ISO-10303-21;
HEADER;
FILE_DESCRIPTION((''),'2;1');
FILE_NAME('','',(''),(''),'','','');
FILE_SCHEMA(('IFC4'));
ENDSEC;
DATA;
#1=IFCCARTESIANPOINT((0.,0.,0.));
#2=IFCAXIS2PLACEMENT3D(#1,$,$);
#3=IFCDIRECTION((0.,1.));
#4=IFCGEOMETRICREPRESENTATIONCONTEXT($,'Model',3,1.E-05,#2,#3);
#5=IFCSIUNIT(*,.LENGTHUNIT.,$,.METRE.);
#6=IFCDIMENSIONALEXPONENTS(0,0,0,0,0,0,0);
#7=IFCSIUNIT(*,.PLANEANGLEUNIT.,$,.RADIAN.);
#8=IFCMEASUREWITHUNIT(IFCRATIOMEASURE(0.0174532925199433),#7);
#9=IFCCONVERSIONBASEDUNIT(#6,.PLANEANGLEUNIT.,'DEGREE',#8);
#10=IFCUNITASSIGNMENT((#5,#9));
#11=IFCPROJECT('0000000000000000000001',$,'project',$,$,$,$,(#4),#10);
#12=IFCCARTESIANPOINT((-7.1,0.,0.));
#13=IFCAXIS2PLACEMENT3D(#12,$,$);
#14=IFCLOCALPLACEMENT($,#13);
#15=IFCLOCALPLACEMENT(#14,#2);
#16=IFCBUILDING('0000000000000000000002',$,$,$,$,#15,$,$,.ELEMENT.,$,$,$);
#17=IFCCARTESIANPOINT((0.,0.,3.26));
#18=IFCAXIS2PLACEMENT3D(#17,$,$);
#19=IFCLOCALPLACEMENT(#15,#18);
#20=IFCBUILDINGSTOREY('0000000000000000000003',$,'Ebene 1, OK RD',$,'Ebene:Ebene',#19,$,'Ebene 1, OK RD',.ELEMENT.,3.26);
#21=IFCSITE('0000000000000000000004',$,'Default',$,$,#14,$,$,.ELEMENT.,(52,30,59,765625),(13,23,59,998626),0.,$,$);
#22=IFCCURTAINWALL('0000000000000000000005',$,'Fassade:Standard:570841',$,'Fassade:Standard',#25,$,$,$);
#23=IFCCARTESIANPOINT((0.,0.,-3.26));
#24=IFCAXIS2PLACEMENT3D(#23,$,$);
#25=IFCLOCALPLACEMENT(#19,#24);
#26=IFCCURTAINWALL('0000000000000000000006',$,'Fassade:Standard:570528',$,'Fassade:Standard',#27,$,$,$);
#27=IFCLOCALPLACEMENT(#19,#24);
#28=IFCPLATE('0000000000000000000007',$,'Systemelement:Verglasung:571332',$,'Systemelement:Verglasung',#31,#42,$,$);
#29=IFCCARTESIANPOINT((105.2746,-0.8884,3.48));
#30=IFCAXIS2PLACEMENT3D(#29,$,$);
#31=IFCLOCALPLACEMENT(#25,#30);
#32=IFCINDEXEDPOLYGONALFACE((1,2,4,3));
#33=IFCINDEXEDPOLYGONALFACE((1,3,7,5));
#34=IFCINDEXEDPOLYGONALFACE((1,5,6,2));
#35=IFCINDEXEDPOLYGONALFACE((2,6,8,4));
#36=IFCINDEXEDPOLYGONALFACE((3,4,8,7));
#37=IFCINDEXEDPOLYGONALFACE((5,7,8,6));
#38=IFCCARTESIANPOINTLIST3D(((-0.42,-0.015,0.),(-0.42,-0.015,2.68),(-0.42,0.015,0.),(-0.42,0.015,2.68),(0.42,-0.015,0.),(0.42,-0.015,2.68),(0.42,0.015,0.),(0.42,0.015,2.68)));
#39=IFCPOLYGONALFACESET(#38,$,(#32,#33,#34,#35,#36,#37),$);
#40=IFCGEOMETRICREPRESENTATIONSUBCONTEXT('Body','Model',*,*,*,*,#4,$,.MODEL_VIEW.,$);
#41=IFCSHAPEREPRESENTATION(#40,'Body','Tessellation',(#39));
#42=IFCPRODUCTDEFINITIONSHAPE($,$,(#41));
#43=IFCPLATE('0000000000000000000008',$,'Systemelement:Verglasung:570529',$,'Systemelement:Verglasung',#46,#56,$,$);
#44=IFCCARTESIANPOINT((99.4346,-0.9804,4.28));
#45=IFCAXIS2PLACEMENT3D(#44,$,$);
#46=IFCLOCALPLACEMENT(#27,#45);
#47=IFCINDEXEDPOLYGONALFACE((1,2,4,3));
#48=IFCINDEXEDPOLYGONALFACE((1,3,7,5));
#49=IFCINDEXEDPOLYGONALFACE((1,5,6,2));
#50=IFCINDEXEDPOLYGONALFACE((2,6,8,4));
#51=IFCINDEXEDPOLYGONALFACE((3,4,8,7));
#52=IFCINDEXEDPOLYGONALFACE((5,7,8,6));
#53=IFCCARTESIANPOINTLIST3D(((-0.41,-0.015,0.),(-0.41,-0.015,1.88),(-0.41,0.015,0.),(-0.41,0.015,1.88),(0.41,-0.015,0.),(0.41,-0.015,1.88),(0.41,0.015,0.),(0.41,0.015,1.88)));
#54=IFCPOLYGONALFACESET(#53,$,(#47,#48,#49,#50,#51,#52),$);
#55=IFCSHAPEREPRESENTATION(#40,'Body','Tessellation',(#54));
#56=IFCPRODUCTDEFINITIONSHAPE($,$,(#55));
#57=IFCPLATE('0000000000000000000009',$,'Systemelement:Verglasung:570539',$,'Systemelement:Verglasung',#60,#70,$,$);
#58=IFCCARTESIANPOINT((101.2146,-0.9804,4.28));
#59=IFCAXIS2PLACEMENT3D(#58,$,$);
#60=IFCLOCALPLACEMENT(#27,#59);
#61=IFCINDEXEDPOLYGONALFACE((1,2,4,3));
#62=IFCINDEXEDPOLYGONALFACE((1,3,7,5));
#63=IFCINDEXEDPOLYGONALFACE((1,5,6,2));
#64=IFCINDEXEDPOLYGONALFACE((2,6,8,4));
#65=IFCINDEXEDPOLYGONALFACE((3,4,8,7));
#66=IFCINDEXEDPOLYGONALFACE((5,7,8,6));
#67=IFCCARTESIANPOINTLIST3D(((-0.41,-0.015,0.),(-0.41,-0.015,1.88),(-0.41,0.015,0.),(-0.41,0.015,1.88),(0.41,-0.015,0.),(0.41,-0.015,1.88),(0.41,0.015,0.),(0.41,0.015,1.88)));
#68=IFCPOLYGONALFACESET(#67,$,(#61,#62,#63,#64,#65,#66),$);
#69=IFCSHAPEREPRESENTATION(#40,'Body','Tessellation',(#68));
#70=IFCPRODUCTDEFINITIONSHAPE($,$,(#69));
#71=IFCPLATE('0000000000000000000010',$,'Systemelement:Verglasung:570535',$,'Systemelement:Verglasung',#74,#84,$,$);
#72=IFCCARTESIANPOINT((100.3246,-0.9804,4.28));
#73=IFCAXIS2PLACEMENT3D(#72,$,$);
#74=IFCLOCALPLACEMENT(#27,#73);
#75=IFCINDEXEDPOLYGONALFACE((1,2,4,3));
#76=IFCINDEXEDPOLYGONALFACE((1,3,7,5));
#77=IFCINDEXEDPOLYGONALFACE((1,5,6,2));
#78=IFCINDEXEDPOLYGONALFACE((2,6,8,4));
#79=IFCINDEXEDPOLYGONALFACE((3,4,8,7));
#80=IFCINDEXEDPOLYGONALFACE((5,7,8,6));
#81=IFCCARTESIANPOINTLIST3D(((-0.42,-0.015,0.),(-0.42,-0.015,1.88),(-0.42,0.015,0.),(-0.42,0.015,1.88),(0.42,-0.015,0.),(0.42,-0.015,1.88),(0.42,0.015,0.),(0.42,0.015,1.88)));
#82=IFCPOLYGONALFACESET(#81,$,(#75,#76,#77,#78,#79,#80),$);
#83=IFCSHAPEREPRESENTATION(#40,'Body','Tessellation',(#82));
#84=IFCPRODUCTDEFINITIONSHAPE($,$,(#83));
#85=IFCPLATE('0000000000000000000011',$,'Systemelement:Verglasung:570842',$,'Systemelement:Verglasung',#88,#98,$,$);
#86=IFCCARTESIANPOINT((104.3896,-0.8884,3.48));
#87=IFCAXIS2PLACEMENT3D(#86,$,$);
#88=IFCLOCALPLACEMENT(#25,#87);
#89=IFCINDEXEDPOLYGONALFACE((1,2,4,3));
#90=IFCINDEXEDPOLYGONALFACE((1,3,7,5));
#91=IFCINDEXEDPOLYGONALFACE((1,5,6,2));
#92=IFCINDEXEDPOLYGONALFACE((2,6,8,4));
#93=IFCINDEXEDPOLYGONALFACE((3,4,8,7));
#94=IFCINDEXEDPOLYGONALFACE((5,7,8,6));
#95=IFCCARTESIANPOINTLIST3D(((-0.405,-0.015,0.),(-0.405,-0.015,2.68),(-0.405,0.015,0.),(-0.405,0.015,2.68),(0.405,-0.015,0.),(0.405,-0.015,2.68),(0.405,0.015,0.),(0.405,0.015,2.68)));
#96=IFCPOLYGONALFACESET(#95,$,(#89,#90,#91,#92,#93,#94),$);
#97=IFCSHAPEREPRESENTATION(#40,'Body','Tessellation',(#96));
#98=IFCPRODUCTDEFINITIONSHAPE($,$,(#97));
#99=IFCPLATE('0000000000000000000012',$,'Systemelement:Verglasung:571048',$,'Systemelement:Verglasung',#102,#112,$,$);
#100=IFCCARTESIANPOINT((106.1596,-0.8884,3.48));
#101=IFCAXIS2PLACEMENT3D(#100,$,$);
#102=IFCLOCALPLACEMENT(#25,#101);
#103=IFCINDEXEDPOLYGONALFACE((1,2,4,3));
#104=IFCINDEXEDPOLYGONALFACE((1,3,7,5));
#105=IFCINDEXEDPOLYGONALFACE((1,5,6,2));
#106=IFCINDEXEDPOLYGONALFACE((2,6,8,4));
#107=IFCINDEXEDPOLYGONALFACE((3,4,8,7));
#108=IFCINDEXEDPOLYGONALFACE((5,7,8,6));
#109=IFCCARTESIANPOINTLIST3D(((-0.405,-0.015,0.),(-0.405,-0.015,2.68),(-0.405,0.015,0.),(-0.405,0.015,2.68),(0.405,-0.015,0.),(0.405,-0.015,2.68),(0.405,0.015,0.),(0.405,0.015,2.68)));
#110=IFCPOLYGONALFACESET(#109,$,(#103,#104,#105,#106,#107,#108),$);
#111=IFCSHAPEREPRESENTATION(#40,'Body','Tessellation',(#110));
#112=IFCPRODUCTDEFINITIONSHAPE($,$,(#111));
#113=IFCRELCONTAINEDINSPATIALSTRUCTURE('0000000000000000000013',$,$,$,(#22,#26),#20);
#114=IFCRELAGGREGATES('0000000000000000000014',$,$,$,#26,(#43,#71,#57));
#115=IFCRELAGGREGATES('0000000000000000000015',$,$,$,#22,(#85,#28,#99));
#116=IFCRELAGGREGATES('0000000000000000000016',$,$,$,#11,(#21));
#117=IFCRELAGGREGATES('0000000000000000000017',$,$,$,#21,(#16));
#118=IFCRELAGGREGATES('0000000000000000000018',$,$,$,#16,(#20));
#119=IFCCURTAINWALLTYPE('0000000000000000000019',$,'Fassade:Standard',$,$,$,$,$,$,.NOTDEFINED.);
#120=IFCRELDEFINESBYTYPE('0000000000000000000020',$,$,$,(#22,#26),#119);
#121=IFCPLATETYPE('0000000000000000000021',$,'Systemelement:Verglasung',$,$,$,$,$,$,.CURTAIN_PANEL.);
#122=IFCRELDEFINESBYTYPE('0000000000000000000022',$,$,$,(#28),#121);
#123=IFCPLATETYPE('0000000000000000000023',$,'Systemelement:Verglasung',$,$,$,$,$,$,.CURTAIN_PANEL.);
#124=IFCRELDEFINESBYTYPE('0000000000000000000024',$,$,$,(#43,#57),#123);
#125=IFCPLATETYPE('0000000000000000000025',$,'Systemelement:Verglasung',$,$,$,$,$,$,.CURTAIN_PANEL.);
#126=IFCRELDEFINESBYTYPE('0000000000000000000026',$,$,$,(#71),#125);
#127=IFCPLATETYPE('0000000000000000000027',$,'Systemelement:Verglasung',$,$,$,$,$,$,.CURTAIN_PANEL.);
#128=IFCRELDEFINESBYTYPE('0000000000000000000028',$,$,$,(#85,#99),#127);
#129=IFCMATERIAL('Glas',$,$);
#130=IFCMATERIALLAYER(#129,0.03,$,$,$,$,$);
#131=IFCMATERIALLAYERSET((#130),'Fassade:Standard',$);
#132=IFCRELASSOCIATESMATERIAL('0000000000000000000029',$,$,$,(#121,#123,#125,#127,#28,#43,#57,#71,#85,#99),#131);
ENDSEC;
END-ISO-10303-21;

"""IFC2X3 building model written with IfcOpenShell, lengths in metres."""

from ifc_helpers import new_model, entity, si_unit, converted_unit, direction, frame, origin, origin_2d_with_axis, place, context, subcontext, project, spatial, rectangle, extrude, source, transform, mapped, material, layer, layer_set, layer_usage, type_object, type_shapes, element, aggregate, save


model = new_model("IFC2X3")

# Units and contexts
model_context = context("Model", 3, precision=1e-05, world=origin(), true_north=direction((0.0, 1.0)))
body_context = subcontext(model_context, "Body", "Model", "MODEL_VIEW")
ifc_project = project(units=[si_unit("LENGTHUNIT", "METRE"), converted_unit("PLANEANGLEUNIT", "DEGREE", entity("IfcRatioMeasure", 0.0174532925199433), si_unit("PLANEANGLEUNIT", "RADIAN"), dimensions=[0, 0, 0, 0, 0, 0, 0])], contexts=[model_context])

# Site, building, storey
site_placement = place(None, frame((-7.1, 0.0, 0.0)))
site = spatial("IfcSite", under=ifc_project, at=site_placement, Name="Default", CompositionType="ELEMENT", RefLatitude=(52, 30, 59, 765625), RefLongitude=(13, 23, 59, 998626), RefElevation=0.0)
building_placement = place(site_placement, origin())
building = spatial("IfcBuilding", under=site, at=building_placement, CompositionType="ELEMENT")
storey_placement = place(building_placement, frame((0.0, 0.0, 3.26)))
storey = spatial("IfcBuildingStorey", under=building, at=storey_placement, Name="Ebene 1, OK RD", ObjectType="Ebene:Ebene", LongName="Ebene 1, OK RD", CompositionType="ELEMENT", Elevation=3.26)

# Curtain wall
curtain_wall_type = type_object("IfcCurtainWallType", Name="Fassade:Standard", PredefinedType="NOTDEFINED")
curtain_wall_1_placement = place(storey_placement, frame((0.0, 0.0, -3.26)))
curtain_wall_1 = element("IfcCurtainWall", 1, at=curtain_wall_1_placement, inside=storey, type_object=curtain_wall_type, Name="Fassade:Standard:570841", ObjectType="Fassade:Standard")

# Curtain wall
curtain_wall_2_placement = place(storey_placement, frame((0.0, 0.0, -3.26)))
curtain_wall_2 = element("IfcCurtainWall", 2, at=curtain_wall_2_placement, inside=storey, type_object=curtain_wall_type, Name="Fassade:Standard:570528", ObjectType="Fassade:Standard")

# Plates
ifc_material_1 = material(Name="Glas")
ifc_layer_1 = layer(ifc_material_1, 0.03)
ifc_layer_set_1 = layer_set([ifc_layer_1], Name="Fassade:Standard")
ifc_layer_usage_1 = layer_usage(ifc_layer_set_1, "AXIS3", "POSITIVE", 0.0)
plate_type_1 = type_object("IfcPlateType", Name="Systemelement:Verglasung", PredefinedType="CURTAIN_PANEL", material=ifc_layer_set_1)
shared_shape_1 = source(origin(), body_context, "Body", "SweptSolid", [
    extrude(rectangle(XDim=0.03, YDim=0.84, at=origin_2d_with_axis()), frame((0.0, 0.0, 0.0), z_axis=(0.0, 0.0, 1.0), x_axis=(0.0, 1.0, 0.0)), (0.0, 0.0, 1.0), 2.68),
])
type_shapes(plate_type_1, [shared_shape_1])
plate_1_placement = place(curtain_wall_1_placement, frame((105.2746, -0.8884, 3.48)))
plate_1 = element("IfcPlate", 3, at=plate_1_placement, type_object=plate_type_1, material=ifc_layer_usage_1, Name="Systemelement:Verglasung:571332", ObjectType="Systemelement:Verglasung", context=body_context, shape_type="MappedRepresentation", body=[
    mapped(shared_shape_1, transform((0.0, 0.0, 0.0), scale=1.0)),
])
ifc_layer_usage_2 = layer_usage(ifc_layer_set_1, "AXIS3", "POSITIVE", 0.0)
plate_type_2 = type_object("IfcPlateType", Name="Systemelement:Verglasung", PredefinedType="CURTAIN_PANEL", material=ifc_layer_set_1)
shared_shape_2 = source(origin(), body_context, "Body", "SweptSolid", [
    extrude(rectangle(XDim=0.03, YDim=0.82, at=origin_2d_with_axis()), frame((0.0, 0.0, 0.0), z_axis=(0.0, 0.0, 1.0), x_axis=(0.0, 1.0, 0.0)), (0.0, 0.0, 1.0), 1.88),
])
type_shapes(plate_type_2, [shared_shape_2])
plate_2_placement = place(curtain_wall_2_placement, frame((99.4346, -0.9804, 4.28)))
plate_2 = element("IfcPlate", 4, at=plate_2_placement, type_object=plate_type_2, material=ifc_layer_usage_2, Name="Systemelement:Verglasung:570529", ObjectType="Systemelement:Verglasung", context=body_context, shape_type="MappedRepresentation", body=[
    mapped(shared_shape_2, transform((0.0, 0.0, 0.0), scale=1.0)),
])
ifc_layer_usage_3 = layer_usage(ifc_layer_set_1, "AXIS3", "POSITIVE", 0.0)
plate_3_placement = place(curtain_wall_2_placement, frame((101.2146, -0.9804, 4.28)))
plate_3 = element("IfcPlate", 5, at=plate_3_placement, type_object=plate_type_2, material=ifc_layer_usage_3, Name="Systemelement:Verglasung:570539", ObjectType="Systemelement:Verglasung", context=body_context, shape_type="MappedRepresentation", body=[
    mapped(shared_shape_2, transform((0.0, 0.0, 0.0), scale=1.0)),
])
ifc_layer_usage_4 = layer_usage(ifc_layer_set_1, "AXIS3", "POSITIVE", 0.0)
plate_type_3 = type_object("IfcPlateType", Name="Systemelement:Verglasung", PredefinedType="CURTAIN_PANEL", material=ifc_layer_set_1)
shared_shape_3 = source(origin(), body_context, "Body", "SweptSolid", [
    extrude(rectangle(XDim=0.03, YDim=0.84, at=origin_2d_with_axis()), frame((0.0, 0.0, 0.0), z_axis=(0.0, 0.0, 1.0), x_axis=(0.0, 1.0, 0.0)), (0.0, 0.0, 1.0), 1.88),
])
type_shapes(plate_type_3, [shared_shape_3])
plate_4_placement = place(curtain_wall_2_placement, frame((100.3246, -0.9804, 4.28)))
plate_4 = element("IfcPlate", 6, at=plate_4_placement, type_object=plate_type_3, material=ifc_layer_usage_4, Name="Systemelement:Verglasung:570535", ObjectType="Systemelement:Verglasung", context=body_context, shape_type="MappedRepresentation", body=[
    mapped(shared_shape_3, transform((0.0, 0.0, 0.0), scale=1.0)),
])
aggregate(curtain_wall_2, [plate_2, plate_4, plate_3])
ifc_layer_usage_5 = layer_usage(ifc_layer_set_1, "AXIS3", "POSITIVE", 0.0)
plate_type_4 = type_object("IfcPlateType", Name="Systemelement:Verglasung", PredefinedType="CURTAIN_PANEL", material=ifc_layer_set_1)
shared_shape_4 = source(origin(), body_context, "Body", "SweptSolid", [
    extrude(rectangle(XDim=0.03, YDim=0.81, at=origin_2d_with_axis()), frame((0.0, 0.0, 0.0), z_axis=(0.0, 0.0, 1.0), x_axis=(0.0, 1.0, 0.0)), (0.0, 0.0, 1.0), 2.68),
])
type_shapes(plate_type_4, [shared_shape_4])
plate_5_placement = place(curtain_wall_1_placement, frame((104.3896, -0.8884, 3.48)))
plate_5 = element("IfcPlate", 7, at=plate_5_placement, type_object=plate_type_4, material=ifc_layer_usage_5, Name="Systemelement:Verglasung:570842", ObjectType="Systemelement:Verglasung", context=body_context, shape_type="MappedRepresentation", body=[
    mapped(shared_shape_4, transform((0.0, 0.0, 0.0), scale=1.0)),
])
ifc_layer_usage_6 = layer_usage(ifc_layer_set_1, "AXIS3", "POSITIVE", 0.0)
plate_6_placement = place(curtain_wall_1_placement, frame((106.1596, -0.8884, 3.48)))
plate_6 = element("IfcPlate", 8, at=plate_6_placement, type_object=plate_type_4, material=ifc_layer_usage_6, Name="Systemelement:Verglasung:571048", ObjectType="Systemelement:Verglasung", context=body_context, shape_type="MappedRepresentation", body=[
    mapped(shared_shape_4, transform((0.0, 0.0, 0.0), scale=1.0)),
])
aggregate(curtain_wall_1, [plate_5, plate_1, plate_6])

save(model, "model.ifc")
